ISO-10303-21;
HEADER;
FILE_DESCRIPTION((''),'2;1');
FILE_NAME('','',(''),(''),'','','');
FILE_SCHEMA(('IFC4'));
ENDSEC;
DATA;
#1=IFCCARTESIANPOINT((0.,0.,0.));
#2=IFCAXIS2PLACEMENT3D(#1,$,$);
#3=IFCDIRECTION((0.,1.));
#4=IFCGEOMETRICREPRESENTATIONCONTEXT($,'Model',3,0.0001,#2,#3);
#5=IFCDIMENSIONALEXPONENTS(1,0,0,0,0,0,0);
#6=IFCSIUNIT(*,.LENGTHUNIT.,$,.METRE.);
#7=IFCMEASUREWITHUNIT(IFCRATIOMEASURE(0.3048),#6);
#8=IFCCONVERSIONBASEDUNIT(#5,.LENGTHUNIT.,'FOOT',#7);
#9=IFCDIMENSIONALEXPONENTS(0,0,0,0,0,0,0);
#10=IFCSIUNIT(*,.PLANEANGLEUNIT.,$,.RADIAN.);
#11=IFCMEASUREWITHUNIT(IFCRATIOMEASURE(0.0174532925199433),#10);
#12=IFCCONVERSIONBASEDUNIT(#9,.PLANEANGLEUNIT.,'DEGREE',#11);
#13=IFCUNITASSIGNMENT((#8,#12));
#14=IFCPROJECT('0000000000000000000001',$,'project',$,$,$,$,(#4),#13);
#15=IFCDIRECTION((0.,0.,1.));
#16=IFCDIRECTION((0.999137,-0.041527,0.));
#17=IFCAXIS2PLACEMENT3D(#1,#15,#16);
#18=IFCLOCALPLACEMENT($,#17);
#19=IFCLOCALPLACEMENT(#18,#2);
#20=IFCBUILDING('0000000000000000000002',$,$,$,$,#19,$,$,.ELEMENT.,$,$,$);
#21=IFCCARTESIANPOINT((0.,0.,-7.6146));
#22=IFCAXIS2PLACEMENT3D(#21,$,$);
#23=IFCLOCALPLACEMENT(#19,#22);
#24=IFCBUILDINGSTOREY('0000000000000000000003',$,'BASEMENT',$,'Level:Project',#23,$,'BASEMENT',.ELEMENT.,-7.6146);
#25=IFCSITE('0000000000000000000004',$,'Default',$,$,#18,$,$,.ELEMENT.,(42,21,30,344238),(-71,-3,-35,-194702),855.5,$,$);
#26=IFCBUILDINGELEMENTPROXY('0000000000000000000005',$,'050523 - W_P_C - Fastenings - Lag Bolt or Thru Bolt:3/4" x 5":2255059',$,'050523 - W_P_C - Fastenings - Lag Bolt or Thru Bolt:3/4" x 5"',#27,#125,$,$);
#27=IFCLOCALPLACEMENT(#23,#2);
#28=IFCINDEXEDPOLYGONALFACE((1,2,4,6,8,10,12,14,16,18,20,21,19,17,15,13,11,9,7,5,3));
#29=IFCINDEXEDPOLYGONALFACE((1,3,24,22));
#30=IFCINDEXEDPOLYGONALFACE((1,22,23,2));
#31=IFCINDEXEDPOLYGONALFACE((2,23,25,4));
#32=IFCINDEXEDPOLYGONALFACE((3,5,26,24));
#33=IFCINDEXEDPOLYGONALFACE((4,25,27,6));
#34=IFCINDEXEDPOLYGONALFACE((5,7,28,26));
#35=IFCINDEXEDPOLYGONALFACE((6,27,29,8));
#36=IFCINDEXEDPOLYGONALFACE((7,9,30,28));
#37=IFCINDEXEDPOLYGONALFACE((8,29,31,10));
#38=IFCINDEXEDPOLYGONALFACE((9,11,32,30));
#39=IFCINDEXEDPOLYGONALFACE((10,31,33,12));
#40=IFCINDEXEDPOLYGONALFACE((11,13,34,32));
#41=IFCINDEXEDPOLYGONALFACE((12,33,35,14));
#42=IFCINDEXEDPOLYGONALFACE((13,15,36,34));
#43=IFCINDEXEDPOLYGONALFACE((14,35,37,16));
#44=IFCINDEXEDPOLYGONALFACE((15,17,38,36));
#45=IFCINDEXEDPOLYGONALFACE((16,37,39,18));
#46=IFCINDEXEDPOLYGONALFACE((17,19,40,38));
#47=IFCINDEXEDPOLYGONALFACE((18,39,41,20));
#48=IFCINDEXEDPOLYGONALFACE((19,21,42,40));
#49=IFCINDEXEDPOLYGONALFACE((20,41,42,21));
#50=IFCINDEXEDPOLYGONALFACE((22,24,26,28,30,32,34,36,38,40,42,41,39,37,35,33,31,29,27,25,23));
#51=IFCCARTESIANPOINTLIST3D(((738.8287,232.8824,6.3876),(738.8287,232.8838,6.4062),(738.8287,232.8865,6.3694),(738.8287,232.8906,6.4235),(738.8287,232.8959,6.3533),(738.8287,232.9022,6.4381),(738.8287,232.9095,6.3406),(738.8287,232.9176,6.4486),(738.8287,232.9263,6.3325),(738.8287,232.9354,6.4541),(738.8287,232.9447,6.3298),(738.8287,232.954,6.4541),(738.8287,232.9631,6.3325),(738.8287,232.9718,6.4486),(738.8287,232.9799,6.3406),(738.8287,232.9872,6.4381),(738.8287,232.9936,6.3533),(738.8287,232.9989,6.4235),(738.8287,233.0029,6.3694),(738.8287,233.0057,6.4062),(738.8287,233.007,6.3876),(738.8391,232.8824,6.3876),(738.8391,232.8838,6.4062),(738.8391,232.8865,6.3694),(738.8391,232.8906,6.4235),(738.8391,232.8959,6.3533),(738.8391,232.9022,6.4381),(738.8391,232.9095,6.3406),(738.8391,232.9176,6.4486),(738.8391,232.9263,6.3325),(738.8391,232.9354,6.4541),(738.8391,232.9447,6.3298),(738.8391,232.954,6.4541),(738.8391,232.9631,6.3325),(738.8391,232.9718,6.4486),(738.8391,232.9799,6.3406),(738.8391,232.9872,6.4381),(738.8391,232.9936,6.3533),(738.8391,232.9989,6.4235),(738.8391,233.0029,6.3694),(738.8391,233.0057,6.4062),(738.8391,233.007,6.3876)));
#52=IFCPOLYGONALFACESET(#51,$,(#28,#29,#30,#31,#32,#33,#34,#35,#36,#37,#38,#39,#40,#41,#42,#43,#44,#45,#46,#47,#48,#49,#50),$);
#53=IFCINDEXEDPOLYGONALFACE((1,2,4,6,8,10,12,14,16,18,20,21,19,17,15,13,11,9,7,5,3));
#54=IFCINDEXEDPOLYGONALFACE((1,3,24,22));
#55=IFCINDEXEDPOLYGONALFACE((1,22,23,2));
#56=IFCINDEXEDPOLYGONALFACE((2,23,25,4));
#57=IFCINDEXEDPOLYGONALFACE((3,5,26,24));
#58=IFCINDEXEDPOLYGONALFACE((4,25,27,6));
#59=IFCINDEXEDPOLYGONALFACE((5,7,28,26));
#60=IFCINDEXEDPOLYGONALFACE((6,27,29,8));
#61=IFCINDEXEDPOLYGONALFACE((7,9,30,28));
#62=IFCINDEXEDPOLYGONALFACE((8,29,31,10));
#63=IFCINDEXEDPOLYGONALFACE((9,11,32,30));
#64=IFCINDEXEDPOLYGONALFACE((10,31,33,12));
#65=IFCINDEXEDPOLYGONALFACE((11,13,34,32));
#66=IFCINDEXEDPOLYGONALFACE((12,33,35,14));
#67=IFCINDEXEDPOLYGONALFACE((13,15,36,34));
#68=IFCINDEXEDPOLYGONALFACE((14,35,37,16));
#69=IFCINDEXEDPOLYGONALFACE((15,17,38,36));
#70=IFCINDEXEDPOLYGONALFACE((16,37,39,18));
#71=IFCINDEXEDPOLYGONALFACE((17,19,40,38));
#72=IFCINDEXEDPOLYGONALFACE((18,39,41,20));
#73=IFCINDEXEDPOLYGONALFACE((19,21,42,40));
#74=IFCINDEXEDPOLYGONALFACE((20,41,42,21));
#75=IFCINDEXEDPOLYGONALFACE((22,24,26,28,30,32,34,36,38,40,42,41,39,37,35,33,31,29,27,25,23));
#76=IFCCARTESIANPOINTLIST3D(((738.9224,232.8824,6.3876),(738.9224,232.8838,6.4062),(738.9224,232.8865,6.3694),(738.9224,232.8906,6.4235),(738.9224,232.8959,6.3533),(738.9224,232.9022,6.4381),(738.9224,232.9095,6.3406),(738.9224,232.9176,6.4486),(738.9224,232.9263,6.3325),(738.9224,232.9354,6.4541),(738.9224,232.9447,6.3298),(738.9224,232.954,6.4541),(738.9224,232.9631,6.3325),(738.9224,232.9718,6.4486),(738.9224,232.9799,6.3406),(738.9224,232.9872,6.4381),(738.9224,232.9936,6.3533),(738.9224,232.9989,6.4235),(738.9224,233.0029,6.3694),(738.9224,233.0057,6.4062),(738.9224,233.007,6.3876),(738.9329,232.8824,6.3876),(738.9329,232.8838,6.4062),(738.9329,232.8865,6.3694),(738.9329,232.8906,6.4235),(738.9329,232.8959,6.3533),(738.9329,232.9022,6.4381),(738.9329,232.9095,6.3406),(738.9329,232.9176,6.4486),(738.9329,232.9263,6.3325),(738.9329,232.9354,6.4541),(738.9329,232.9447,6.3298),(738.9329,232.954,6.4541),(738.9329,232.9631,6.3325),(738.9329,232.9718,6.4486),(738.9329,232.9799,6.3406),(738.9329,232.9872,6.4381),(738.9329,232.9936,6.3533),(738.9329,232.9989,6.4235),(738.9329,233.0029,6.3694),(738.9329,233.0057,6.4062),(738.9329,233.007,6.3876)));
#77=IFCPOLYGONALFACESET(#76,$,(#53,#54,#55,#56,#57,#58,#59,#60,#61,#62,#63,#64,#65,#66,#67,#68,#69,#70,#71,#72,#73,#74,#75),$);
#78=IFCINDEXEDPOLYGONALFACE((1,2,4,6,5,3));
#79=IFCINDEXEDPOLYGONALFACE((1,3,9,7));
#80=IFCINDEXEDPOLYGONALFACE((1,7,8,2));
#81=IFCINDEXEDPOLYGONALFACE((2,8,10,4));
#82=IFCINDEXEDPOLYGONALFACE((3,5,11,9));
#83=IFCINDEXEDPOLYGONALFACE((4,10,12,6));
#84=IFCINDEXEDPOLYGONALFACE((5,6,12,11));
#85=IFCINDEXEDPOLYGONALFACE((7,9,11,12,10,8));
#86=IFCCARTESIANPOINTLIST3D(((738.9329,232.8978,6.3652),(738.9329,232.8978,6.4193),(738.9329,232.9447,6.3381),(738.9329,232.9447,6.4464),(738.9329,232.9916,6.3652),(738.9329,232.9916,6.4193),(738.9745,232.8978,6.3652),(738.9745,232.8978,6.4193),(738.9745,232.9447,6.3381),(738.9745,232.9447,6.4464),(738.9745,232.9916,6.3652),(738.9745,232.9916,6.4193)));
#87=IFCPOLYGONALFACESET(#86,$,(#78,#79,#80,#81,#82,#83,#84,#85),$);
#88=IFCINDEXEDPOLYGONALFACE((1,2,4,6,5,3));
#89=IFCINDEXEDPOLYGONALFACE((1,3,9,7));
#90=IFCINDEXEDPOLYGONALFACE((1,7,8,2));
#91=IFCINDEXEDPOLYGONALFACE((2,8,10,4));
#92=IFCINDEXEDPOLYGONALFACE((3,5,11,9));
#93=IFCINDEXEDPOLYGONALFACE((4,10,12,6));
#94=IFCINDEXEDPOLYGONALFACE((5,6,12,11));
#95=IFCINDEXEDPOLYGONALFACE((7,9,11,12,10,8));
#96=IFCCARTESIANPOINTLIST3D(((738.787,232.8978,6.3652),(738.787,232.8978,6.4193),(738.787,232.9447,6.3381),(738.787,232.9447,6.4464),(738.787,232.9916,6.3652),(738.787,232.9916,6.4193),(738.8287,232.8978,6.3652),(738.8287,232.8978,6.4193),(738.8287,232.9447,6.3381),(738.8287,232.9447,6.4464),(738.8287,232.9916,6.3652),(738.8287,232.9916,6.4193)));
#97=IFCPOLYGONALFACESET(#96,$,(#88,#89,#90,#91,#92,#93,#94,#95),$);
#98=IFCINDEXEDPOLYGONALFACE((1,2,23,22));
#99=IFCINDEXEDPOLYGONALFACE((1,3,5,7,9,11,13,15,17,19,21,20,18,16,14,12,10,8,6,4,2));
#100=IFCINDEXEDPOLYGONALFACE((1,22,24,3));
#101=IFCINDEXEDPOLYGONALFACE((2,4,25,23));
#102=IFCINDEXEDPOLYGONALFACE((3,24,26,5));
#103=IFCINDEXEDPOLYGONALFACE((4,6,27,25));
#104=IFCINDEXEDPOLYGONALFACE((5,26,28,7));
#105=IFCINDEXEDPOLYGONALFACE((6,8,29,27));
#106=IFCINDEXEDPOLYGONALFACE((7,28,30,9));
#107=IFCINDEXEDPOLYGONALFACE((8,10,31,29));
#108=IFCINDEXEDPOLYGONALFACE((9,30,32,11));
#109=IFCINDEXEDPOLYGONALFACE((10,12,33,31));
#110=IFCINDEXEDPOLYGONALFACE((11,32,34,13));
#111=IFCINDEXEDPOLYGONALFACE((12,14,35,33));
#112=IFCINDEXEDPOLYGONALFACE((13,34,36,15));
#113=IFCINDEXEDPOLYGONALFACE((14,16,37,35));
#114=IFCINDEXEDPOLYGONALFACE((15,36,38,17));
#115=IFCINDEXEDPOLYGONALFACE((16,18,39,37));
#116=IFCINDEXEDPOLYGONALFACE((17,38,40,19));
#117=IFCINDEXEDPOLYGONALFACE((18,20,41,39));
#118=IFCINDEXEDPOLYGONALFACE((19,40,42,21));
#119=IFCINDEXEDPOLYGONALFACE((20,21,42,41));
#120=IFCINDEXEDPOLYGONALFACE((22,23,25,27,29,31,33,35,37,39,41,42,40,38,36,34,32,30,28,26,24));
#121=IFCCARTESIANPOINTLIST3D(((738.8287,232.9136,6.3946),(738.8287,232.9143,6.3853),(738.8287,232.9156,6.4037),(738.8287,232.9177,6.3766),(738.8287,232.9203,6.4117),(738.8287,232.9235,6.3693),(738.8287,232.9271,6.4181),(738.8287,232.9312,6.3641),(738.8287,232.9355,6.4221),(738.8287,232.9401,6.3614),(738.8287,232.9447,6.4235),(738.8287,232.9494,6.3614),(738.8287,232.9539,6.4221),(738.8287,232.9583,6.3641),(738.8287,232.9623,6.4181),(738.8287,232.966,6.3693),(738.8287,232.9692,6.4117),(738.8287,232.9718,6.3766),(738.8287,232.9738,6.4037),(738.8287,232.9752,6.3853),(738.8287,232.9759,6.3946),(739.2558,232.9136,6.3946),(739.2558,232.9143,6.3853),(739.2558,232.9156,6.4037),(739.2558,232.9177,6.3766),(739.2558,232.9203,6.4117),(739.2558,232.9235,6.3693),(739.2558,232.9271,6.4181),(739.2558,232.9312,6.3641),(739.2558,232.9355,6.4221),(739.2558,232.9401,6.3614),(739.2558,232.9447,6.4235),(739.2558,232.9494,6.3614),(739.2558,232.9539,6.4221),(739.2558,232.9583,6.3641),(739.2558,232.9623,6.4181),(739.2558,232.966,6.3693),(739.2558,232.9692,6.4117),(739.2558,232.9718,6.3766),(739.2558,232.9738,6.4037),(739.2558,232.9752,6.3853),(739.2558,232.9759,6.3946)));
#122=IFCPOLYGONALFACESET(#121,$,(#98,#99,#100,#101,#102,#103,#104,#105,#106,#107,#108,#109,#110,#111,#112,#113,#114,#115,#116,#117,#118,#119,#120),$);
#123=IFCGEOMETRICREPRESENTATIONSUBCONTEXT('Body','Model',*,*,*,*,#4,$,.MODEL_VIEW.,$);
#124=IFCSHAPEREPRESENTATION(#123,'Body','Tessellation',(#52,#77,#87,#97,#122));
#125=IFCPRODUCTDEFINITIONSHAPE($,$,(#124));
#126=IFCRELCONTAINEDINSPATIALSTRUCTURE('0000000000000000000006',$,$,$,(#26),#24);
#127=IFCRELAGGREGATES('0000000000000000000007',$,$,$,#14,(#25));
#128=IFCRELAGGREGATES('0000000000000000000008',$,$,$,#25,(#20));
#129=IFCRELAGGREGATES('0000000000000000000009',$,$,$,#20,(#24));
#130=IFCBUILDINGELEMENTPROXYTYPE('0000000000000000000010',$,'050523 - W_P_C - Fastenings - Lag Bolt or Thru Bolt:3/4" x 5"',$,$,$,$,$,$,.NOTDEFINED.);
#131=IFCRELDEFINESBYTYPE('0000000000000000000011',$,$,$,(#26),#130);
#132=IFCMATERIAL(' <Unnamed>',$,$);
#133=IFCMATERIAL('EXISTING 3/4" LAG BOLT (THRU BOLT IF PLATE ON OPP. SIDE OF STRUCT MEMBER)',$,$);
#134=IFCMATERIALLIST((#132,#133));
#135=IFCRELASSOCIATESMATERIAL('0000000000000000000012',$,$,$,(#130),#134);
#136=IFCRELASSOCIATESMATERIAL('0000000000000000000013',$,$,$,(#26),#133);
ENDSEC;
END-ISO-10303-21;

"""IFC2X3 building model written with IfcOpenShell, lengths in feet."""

from ifc_helpers import new_model, entity, si_unit, converted_unit, direction, frame, frame_2d, origin, place, context, subcontext, project, spatial, polyline, circle, outline, extrude, source, transform, mapped, material, material_list, type_object, type_shapes, element, save


model = new_model("IFC2X3")

# Units and contexts
model_context = context("Model", 3, precision=0.0001, world=origin(), true_north=direction((0.0, 1.0)))
body_context = subcontext(model_context, "Body", "Model", "MODEL_VIEW")
ifc_project = project(units=[converted_unit("LENGTHUNIT", "FOOT", entity("IfcRatioMeasure", 0.3048), si_unit("LENGTHUNIT", "METRE"), dimensions=[1, 0, 0, 0, 0, 0, 0]), converted_unit("PLANEANGLEUNIT", "DEGREE", entity("IfcRatioMeasure", 0.0174532925199433), si_unit("PLANEANGLEUNIT", "RADIAN"), dimensions=[0, 0, 0, 0, 0, 0, 0])], contexts=[model_context])

# Site, building, storey
site_placement = place(None, frame((0.0, 0.0, 0.0), z_axis=(0.0, 0.0, 1.0), x_axis=(0.999137, -0.041527, 0.0)))
site = spatial("IfcSite", under=ifc_project, at=site_placement, Name="Default", CompositionType="ELEMENT", RefLatitude=(42, 21, 30, 344238), RefLongitude=(-71, -3, -35, -194702), RefElevation=855.5)
building_placement = place(site_placement, origin())
building = spatial("IfcBuilding", under=site, at=building_placement, CompositionType="ELEMENT")
storey_placement = place(building_placement, frame((0.0, 0.0, -7.6146)))
storey = spatial("IfcBuildingStorey", under=building, at=storey_placement, Name="BASEMENT", ObjectType="Level:Project", LongName="BASEMENT", CompositionType="ELEMENT", Elevation=-7.6146)

# Building element proxy
ifc_material_1 = material(Name="EXISTING 3/4\" LAG BOLT (THRU BOLT IF PLATE ON OPP. SIDE OF STRUCT MEMBER)")
ifc_material_2 = material(Name=" <Unnamed>")
ifc_material_list_1 = material_list([ifc_material_2, ifc_material_1])
building_element_proxy_type_1 = type_object("IfcBuildingElementProxyType", Name="050523 - W_P_C - Fastenings - Lag Bolt or Thru Bolt:3/4\" x 5\"", PredefinedType="NOTDEFINED", material=ifc_material_list_1)
shared_shape_1 = source(origin(), body_context, "Body", "SweptSolid", [
    extrude(circle(Radius=0.0625, at=frame_2d((0.0, 0.0), x_axis=(1.0, 0.0))), frame((0.0, 0.0, 0.0), z_axis=(0.0, 0.0, 1.0), x_axis=(0.0, -1.0, 0.0)), (0.0, 0.0, 1.0), 0.0104),
    extrude(circle(Radius=0.0625, at=frame_2d((0.0, 0.0), x_axis=(1.0, 0.0))), frame((0.0, 0.0, -0.0938), z_axis=(0.0, 0.0, 1.0), x_axis=(0.0, -1.0, 0.0)), (0.0, 0.0, 1.0), 0.0104),
    extrude(outline(polyline([(-0.0271, -0.0469), (0.0271, -0.0469), (0.0541, 0.0), (0.0271, 0.0469), (-0.0271, 0.0469), (-0.0541, 0.0), (-0.0271, -0.0469)])), frame((0.0, 0.0, -0.1354), z_axis=(0.0, 0.0, 1.0), x_axis=(0.866025, -0.5, 0.0)), (0.0, 0.0, 1.0), 0.0417),
    extrude(outline(polyline([(-0.0271, -0.0469), (0.0271, -0.0469), (0.0541, 0.0), (0.0271, 0.0469), (-0.0271, 0.0469), (-0.0541, 0.0), (-0.0271, -0.0469)])), frame((0.0, 0.0, 0.0104), z_axis=(0.0, 0.0, 1.0), x_axis=(0.0, -1.0, 0.0)), (0.0, 0.0, 1.0), 0.0417),
    extrude(circle(Radius=0.0312, at=frame_2d((0.0, 0.0), x_axis=(1.0, 0.0))), frame((0.0, 0.0, -0.4167), z_axis=(0.0, 0.0, 1.0), x_axis=(0.0, 1.0, 0.0)), (0.0, 0.0, 1.0), 0.4271),
])
type_shapes(building_element_proxy_type_1, [shared_shape_1])
for number, where, z_axis, x_axis, name in (
    (1, (738.8391, 232.9447, 6.3923), (-1.0, 0.0, 0.0), (0.0, -1.0, 0.0), "050523 - W_P_C - Fastenings - Lag Bolt or Thru Bolt:3/4\" x 5\":2255059"),
):
    element("IfcBuildingElementProxy", number, at=place(storey_placement, frame(where, z_axis=z_axis, x_axis=x_axis)), inside=storey, type_object=building_element_proxy_type_1, material=ifc_material_1, Name=name, ObjectType="050523 - W_P_C - Fastenings - Lag Bolt or Thru Bolt:3/4\" x 5\"", context=body_context, shape_type="MappedRepresentation", body=[
        mapped(shared_shape_1, transform((0.0, 0.0, 0.0), scale=1.0)),
    ])

save(model, "model.ifc")
